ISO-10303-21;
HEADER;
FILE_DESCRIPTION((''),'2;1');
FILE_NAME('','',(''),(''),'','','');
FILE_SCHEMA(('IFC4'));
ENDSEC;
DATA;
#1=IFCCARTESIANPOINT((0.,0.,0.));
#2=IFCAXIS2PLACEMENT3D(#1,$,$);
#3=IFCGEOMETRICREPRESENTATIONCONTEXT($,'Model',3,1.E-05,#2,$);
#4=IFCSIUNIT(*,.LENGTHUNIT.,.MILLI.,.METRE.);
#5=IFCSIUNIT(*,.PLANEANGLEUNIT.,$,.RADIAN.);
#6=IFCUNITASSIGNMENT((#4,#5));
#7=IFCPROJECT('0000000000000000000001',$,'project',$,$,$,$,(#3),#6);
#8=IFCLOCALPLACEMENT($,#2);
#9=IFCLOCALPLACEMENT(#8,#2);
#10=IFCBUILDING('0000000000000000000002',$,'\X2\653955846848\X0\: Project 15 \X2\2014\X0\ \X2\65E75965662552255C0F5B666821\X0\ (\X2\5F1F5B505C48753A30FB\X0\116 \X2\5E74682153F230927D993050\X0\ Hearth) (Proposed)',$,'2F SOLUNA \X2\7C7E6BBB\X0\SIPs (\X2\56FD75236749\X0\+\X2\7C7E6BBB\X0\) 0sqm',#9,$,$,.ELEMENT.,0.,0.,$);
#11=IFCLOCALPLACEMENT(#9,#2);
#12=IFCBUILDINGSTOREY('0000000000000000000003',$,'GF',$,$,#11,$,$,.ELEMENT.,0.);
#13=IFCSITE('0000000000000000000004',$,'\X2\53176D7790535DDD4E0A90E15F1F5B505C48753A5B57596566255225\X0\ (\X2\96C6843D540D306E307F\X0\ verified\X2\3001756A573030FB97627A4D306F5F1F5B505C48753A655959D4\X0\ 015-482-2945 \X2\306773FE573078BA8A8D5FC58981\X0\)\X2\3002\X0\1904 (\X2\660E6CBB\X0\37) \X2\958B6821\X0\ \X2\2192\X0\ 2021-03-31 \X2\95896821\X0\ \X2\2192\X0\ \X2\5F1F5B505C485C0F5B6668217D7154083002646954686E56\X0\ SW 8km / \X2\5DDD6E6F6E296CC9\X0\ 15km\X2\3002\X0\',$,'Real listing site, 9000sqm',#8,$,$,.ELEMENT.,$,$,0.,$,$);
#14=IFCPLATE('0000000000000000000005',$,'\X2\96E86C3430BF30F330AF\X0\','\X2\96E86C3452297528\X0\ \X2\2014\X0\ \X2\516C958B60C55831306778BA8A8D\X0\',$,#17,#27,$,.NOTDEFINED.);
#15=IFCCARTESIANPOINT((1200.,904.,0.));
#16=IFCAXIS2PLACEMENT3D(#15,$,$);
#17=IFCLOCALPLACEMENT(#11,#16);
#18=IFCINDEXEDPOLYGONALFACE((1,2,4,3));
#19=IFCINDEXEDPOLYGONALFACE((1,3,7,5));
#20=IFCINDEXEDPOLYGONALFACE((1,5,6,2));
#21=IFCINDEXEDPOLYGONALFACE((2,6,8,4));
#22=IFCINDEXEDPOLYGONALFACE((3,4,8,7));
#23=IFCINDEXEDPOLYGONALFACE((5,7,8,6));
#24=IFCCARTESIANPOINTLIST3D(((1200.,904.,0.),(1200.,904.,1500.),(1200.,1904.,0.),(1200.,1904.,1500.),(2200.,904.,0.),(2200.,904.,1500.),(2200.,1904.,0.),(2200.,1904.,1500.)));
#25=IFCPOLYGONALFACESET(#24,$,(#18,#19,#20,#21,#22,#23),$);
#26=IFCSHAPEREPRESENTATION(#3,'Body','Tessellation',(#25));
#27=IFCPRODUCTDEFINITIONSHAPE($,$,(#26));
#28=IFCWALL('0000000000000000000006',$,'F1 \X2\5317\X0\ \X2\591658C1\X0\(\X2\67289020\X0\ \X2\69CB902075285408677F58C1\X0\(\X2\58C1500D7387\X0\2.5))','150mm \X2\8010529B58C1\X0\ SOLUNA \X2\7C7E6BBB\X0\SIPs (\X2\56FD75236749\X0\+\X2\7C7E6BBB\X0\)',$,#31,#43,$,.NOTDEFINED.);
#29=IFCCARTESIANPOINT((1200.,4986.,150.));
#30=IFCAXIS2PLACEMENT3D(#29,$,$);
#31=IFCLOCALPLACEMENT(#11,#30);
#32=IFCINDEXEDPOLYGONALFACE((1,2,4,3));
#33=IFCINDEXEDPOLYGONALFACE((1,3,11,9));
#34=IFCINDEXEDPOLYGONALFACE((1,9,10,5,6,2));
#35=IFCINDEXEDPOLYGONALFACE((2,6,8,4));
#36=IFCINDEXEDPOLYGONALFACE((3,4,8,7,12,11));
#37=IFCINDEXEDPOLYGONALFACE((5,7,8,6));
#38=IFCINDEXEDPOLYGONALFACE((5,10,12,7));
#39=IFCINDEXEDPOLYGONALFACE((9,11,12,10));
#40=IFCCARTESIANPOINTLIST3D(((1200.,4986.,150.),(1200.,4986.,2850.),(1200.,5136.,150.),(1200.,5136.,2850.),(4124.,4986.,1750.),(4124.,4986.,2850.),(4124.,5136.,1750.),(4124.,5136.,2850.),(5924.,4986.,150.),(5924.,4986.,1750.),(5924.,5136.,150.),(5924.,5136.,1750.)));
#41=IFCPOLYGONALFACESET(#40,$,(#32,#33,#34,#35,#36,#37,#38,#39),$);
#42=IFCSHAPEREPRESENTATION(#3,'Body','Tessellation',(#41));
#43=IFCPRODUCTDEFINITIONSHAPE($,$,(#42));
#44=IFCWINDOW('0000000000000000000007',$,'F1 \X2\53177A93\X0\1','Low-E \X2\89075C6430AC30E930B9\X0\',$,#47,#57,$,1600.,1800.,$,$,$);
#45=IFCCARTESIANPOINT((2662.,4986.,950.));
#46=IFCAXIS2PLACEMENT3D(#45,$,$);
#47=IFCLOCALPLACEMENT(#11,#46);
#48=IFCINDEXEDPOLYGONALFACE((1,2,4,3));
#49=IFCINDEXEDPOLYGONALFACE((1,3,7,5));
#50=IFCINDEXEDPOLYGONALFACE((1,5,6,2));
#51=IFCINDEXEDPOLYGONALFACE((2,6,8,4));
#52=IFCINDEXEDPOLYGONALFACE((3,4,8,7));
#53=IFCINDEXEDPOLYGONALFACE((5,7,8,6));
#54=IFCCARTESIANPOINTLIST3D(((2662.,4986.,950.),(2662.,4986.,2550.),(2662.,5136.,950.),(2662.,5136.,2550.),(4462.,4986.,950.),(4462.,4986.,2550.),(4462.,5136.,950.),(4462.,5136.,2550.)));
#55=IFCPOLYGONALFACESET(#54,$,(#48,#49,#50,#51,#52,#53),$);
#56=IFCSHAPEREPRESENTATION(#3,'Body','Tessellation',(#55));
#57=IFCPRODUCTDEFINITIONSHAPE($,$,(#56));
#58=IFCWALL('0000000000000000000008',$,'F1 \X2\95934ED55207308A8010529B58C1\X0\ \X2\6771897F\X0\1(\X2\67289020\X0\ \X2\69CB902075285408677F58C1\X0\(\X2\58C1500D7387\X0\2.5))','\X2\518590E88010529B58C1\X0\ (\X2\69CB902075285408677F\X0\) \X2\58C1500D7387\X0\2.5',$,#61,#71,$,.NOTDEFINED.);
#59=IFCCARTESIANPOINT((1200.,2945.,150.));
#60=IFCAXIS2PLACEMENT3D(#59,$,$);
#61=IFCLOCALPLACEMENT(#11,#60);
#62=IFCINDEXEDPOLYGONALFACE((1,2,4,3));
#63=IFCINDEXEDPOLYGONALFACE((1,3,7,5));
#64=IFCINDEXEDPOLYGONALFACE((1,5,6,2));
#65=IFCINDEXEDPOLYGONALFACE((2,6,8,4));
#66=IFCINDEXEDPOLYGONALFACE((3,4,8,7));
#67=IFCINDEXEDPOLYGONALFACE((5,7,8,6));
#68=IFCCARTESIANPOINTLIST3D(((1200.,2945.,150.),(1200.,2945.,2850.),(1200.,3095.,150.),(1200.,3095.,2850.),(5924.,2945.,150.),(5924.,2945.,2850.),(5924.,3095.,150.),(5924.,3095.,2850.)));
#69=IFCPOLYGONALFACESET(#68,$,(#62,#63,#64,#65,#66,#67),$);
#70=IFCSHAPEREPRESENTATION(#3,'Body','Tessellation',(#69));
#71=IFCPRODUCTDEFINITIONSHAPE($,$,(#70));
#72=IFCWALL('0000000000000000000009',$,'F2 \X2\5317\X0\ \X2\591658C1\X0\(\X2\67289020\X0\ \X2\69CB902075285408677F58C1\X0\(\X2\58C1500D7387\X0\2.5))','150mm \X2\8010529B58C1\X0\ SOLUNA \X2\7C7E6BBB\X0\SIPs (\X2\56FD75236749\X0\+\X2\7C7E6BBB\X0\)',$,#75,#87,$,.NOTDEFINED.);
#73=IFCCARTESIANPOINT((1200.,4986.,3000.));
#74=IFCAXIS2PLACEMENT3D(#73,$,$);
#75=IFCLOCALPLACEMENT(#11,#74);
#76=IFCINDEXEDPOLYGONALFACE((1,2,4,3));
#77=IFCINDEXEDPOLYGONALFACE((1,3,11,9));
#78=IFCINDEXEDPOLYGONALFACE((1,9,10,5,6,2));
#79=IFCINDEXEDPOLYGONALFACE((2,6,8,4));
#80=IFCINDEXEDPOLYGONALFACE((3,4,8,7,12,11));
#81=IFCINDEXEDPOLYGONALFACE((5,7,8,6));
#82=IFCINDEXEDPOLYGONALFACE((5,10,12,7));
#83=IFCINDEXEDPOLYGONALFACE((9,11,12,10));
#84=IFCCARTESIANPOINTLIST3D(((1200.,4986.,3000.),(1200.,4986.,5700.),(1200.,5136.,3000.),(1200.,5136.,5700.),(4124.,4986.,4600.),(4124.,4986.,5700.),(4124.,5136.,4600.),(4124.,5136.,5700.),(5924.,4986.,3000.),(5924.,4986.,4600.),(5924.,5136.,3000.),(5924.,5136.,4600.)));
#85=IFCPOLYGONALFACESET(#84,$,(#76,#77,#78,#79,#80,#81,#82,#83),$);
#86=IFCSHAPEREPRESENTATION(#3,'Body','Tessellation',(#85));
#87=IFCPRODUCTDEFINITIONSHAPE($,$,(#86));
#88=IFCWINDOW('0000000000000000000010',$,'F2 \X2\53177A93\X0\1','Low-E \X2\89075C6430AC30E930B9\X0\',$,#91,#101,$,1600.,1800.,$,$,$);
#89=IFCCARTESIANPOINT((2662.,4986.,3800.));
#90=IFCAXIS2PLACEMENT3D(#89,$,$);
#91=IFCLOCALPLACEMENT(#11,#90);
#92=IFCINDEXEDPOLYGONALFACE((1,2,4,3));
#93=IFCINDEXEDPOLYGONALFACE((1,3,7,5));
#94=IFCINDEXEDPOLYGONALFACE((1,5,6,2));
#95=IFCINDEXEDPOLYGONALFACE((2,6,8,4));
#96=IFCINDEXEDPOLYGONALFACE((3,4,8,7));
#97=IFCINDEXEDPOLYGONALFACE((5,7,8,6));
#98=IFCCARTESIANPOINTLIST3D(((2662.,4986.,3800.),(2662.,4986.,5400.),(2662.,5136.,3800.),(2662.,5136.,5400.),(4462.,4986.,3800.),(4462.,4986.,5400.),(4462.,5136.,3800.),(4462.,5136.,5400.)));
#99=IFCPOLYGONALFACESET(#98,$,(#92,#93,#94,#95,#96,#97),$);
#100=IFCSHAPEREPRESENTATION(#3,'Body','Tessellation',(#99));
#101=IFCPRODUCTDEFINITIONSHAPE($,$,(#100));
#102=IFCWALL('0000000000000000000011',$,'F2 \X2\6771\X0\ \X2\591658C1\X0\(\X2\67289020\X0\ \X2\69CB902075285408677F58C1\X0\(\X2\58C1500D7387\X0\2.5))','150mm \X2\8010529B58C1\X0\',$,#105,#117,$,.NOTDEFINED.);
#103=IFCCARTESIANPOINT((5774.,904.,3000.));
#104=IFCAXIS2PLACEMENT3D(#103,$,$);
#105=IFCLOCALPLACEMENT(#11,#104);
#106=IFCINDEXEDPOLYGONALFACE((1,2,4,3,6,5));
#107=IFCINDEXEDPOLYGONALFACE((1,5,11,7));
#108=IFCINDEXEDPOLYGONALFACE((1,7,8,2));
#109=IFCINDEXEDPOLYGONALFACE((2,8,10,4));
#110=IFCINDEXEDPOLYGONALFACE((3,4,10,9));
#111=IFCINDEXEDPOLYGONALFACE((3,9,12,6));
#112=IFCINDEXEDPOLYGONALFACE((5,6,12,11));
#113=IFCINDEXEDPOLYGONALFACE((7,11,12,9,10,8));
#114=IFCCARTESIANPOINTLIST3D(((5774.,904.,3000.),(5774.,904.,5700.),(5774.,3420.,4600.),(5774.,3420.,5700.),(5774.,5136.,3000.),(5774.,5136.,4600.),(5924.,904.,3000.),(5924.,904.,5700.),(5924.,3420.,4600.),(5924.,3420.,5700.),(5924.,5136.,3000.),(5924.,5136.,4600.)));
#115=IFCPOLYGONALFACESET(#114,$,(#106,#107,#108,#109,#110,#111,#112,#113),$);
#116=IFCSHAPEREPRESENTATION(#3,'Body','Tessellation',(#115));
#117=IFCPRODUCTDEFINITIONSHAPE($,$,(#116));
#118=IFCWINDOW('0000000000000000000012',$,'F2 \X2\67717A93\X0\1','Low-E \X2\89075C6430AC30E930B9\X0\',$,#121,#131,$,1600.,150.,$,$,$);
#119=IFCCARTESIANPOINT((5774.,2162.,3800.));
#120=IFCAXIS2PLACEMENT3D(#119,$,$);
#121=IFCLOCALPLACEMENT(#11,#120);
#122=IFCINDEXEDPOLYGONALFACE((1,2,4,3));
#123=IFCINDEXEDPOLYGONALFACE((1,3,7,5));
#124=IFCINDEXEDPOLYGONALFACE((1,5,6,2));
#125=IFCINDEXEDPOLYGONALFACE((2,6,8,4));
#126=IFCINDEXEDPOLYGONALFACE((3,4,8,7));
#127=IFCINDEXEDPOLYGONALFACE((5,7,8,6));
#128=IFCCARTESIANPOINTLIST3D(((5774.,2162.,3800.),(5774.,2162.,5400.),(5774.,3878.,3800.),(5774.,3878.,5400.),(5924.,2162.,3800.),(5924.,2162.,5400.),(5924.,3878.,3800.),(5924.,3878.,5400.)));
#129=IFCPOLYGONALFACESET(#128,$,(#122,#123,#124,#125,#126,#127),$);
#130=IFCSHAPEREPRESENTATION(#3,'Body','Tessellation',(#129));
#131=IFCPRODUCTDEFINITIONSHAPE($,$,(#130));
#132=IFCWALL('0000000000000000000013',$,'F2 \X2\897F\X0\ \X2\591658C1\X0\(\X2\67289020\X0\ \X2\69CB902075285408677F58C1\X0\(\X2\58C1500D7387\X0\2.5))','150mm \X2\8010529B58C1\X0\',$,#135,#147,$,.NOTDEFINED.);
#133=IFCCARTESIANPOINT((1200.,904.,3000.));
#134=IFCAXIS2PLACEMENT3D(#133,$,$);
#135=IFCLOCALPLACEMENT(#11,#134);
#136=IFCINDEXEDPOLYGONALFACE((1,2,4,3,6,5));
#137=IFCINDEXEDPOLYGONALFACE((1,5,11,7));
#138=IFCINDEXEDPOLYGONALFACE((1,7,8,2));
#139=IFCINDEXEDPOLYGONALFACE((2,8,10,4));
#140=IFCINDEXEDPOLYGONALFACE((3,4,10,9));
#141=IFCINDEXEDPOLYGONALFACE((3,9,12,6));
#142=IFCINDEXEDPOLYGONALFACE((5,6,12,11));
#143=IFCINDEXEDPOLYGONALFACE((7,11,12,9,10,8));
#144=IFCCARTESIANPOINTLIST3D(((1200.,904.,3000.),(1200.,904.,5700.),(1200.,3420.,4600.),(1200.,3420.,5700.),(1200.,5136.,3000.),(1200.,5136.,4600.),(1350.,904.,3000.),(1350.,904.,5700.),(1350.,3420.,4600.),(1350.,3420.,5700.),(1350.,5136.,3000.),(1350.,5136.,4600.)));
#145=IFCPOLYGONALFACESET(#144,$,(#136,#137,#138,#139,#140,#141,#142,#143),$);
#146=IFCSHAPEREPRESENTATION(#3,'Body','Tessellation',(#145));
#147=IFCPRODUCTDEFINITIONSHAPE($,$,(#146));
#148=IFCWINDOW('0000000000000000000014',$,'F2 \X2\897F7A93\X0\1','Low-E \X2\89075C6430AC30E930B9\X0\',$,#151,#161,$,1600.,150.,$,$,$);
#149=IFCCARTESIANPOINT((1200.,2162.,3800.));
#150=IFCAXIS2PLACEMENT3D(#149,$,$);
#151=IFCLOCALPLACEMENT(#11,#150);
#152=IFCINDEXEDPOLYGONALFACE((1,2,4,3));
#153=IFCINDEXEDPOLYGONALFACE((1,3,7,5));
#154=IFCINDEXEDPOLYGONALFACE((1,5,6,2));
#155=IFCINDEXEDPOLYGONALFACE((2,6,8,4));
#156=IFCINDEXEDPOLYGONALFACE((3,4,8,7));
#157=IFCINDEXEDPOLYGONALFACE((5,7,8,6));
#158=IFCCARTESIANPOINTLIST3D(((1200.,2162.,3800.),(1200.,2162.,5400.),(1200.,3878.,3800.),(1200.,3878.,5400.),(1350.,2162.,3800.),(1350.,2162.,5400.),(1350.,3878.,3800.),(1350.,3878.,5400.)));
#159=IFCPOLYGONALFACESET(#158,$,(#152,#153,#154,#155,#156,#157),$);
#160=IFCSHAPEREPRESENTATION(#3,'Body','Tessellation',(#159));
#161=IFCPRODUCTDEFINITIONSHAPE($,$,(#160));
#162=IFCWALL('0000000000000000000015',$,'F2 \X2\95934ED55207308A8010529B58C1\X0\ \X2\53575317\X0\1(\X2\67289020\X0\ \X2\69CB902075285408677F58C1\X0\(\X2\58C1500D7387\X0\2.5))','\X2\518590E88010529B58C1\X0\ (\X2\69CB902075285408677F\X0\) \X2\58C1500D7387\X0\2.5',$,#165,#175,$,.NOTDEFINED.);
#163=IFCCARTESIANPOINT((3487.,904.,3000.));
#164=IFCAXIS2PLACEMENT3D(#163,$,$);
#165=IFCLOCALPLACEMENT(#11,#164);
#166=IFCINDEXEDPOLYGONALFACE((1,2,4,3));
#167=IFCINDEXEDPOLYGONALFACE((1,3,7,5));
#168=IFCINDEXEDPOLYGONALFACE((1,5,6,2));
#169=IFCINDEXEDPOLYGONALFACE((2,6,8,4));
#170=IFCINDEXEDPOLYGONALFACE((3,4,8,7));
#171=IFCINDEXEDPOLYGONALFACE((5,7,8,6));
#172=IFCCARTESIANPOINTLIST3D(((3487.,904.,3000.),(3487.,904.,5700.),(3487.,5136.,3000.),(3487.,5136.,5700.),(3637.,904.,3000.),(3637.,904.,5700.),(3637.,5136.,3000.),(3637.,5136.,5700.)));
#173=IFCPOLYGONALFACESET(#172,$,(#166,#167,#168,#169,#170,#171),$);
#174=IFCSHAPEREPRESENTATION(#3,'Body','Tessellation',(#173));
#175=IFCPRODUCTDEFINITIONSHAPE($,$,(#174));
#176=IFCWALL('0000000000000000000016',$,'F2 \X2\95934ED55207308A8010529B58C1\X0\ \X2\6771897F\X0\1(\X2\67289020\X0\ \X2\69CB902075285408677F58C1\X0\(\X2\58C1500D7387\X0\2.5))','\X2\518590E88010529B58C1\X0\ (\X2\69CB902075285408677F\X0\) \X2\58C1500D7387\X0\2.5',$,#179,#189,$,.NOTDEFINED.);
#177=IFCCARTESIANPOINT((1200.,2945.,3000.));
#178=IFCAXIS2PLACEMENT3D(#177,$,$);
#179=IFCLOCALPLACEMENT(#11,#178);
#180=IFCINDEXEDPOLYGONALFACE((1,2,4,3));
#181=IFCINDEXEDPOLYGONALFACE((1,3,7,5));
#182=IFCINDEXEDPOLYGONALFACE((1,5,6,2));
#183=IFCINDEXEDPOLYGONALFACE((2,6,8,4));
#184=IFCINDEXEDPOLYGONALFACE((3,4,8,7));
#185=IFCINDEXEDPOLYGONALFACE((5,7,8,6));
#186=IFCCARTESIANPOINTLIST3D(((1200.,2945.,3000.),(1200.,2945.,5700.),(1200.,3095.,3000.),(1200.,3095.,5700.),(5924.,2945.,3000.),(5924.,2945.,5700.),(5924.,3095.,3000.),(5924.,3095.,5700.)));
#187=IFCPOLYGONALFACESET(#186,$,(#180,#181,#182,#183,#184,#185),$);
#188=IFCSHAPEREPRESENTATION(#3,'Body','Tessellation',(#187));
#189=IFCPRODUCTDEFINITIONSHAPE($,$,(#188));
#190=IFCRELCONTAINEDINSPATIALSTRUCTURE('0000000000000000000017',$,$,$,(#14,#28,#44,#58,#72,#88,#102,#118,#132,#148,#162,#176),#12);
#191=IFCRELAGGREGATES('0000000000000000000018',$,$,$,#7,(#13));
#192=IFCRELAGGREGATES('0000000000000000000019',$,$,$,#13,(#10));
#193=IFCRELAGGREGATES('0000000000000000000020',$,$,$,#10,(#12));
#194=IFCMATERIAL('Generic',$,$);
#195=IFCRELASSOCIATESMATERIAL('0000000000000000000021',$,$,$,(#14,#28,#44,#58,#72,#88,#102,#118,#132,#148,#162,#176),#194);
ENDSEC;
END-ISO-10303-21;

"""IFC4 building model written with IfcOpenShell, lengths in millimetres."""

from ifc_helpers import new_model, si_unit, frame, frame_2d, origin, place, context, project, spatial, rectangle, extrude, material, element, fill, save


model = new_model("IFC4")

# Units and contexts
model_context = context("Model", 3, precision=1e-05, world=origin())
ifc_project = project(units=[si_unit("LENGTHUNIT", "METRE", prefix="MILLI"), si_unit("PLANEANGLEUNIT", "RADIAN")], contexts=[model_context])

# Site, building, storey
site_placement = place(None, origin())
site = spatial("IfcSite", under=ifc_project, at=site_placement, Name="北海道川上郡弟子屈町字奥春別 (集落名のみ verified、番地・面積は弟子屈町教委 015-482-2945 で現地確認必要)。1904 (明治37) 開校 → 2021-03-31 閉校 → 弟子屈小学校統合。摩周湖 SW 8km / 川湯温泉 15km。", ObjectType="Real listing site, 9000sqm", CompositionType="ELEMENT", RefElevation=0.0)
building_placement = place(site_placement, origin())
building = spatial("IfcBuilding", under=site, at=building_placement, Name="改善案: Project 15 — 旧奥春別小学校 (弟子屈町・116 年校史を継ぐ Hearth) (Proposed)", ObjectType="2F SOLUNA 籾殻SIPs (国産杉+籾殻) 0sqm", CompositionType="ELEMENT", ElevationOfRefHeight=0.0, ElevationOfTerrain=0.0)
storey_placement = place(building_placement, origin())
storey = spatial("IfcBuildingStorey", under=building, at=storey_placement, Name="GF", CompositionType="ELEMENT", Elevation=0.0)

# Plate
ifc_material_1 = material(Name="Generic")
plate_placement = place(storey_placement, frame((1200.0, 904.0, 0.0)))
element("IfcPlate", 1, at=plate_placement, inside=storey, material=ifc_material_1, Name="雨水タンク", Description="雨水利用 — 公開情報で確認", PredefinedType="NOTDEFINED", context=model_context, shape_type="SweptSolid", body=[
    extrude(rectangle(XDim=1000.0, YDim=1000.0, at=frame_2d((500.0, 500.0))), frame((1200.0, 904.0, 0.0)), (0.0, 0.0, 1.0), 1500.0),
])

# Wall, opening, window
wall_1_placement = place(storey_placement, frame((1200.0, 4986.0, 150.0)))
wall_1 = element("IfcWall", 2, at=wall_1_placement, inside=storey, material=ifc_material_1, Name="F1 北 外壁(木造 構造用合板壁(壁倍率2.5))", Description="150mm 耐力壁 SOLUNA 籾殻SIPs (国産杉+籾殻)", PredefinedType="NOTDEFINED", context=model_context, shape_type="SweptSolid", body=[
    extrude(rectangle(XDim=4724.0, YDim=150.0, at=frame_2d((2362.0, 75.0))), frame((1200.0, 4986.0, 150.0)), (0.0, 0.0, 1.0), 2700.0),
])
opening_1_placement = place(storey_placement, frame((2662.0, 4986.0, 950.0)))
opening_1 = element("IfcOpeningElement", 3, at=opening_1_placement, cuts=wall_1, PredefinedType="NOTDEFINED", context=model_context, shape_type="SweptSolid", body=[
    extrude(rectangle(XDim=1800.0, YDim=150.0, at=frame_2d((900.0, 75.0))), frame((2662.0, 4986.0, 950.0)), (0.0, 0.0, 1.0), 1600.0),
])
window_1_placement = place(storey_placement, frame((2662.0, 4986.0, 950.0)))
window_1 = element("IfcWindow", 4, at=window_1_placement, inside=storey, material=ifc_material_1, Name="F1 北窓1", Description="Low-E 複層ガラス", OverallHeight=1600.0, OverallWidth=1800.0, context=model_context, shape_type="SweptSolid", body=[
    extrude(rectangle(XDim=1800.0, YDim=150.0, at=frame_2d((900.0, 75.0))), frame((2662.0, 4986.0, 950.0)), (0.0, 0.0, 1.0), 1600.0),
])
fill(opening_1, window_1)

# Wall
wall_2_placement = place(storey_placement, frame((1200.0, 2945.0, 150.0)))
element("IfcWall", 5, at=wall_2_placement, inside=storey, material=ifc_material_1, Name="F1 間仕切り耐力壁 東西1(木造 構造用合板壁(壁倍率2.5))", Description="内部耐力壁 (構造用合板) 壁倍率2.5", PredefinedType="NOTDEFINED", context=model_context, shape_type="SweptSolid", body=[
    extrude(rectangle(XDim=4724.0, YDim=150.0, at=frame_2d((2362.0, 75.0))), frame((1200.0, 2945.0, 150.0)), (0.0, 0.0, 1.0), 2700.0),
])

# Walls, openings, windows
wall_3_placement = place(storey_placement, frame((1200.0, 4986.0, 3000.0)))
wall_3 = element("IfcWall", 6, at=wall_3_placement, inside=storey, material=ifc_material_1, Name="F2 北 外壁(木造 構造用合板壁(壁倍率2.5))", Description="150mm 耐力壁 SOLUNA 籾殻SIPs (国産杉+籾殻)", PredefinedType="NOTDEFINED", context=model_context, shape_type="SweptSolid", body=[
    extrude(rectangle(XDim=4724.0, YDim=150.0, at=frame_2d((2362.0, 75.0))), frame((1200.0, 4986.0, 3000.0)), (0.0, 0.0, 1.0), 2700.0),
])
opening_2_placement = place(storey_placement, frame((2662.0, 4986.0, 3800.0)))
opening_2 = element("IfcOpeningElement", 7, at=opening_2_placement, cuts=wall_3, PredefinedType="NOTDEFINED", context=model_context, shape_type="SweptSolid", body=[
    extrude(rectangle(XDim=1800.0, YDim=150.0, at=frame_2d((900.0, 75.0))), frame((2662.0, 4986.0, 3800.0)), (0.0, 0.0, 1.0), 1600.0),
])
window_2_placement = place(storey_placement, frame((2662.0, 4986.0, 3800.0)))
window_2 = element("IfcWindow", 8, at=window_2_placement, inside=storey, material=ifc_material_1, Name="F2 北窓1", Description="Low-E 複層ガラス", OverallHeight=1600.0, OverallWidth=1800.0, context=model_context, shape_type="SweptSolid", body=[
    extrude(rectangle(XDim=1800.0, YDim=150.0, at=frame_2d((900.0, 75.0))), frame((2662.0, 4986.0, 3800.0)), (0.0, 0.0, 1.0), 1600.0),
])
fill(opening_2, window_2)
wall_4_placement = place(storey_placement, frame((5774.0, 904.0, 3000.0)))
wall_4 = element("IfcWall", 9, at=wall_4_placement, inside=storey, material=ifc_material_1, Name="F2 東 外壁(木造 構造用合板壁(壁倍率2.5))", Description="150mm 耐力壁", PredefinedType="NOTDEFINED", context=model_context, shape_type="SweptSolid", body=[
    extrude(rectangle(XDim=150.0, YDim=4232.0, at=frame_2d((75.0, 2116.0))), frame((5774.0, 904.0, 3000.0)), (0.0, 0.0, 1.0), 2700.0),
])
opening_3_placement = place(storey_placement, frame((5774.0, 2162.0, 3800.0)))
opening_3 = element("IfcOpeningElement", 10, at=opening_3_placement, cuts=wall_4, PredefinedType="NOTDEFINED", context=model_context, shape_type="SweptSolid", body=[
    extrude(rectangle(XDim=150.0, YDim=1716.0, at=frame_2d((75.0, 858.0))), frame((5774.0, 2162.0, 3800.0)), (0.0, 0.0, 1.0), 1600.0),
])
window_3_placement = place(storey_placement, frame((5774.0, 2162.0, 3800.0)))
window_3 = element("IfcWindow", 11, at=window_3_placement, inside=storey, material=ifc_material_1, Name="F2 東窓1", Description="Low-E 複層ガラス", OverallHeight=1600.0, OverallWidth=150.0, context=model_context, shape_type="SweptSolid", body=[
    extrude(rectangle(XDim=150.0, YDim=1716.0, at=frame_2d((75.0, 858.0))), frame((5774.0, 2162.0, 3800.0)), (0.0, 0.0, 1.0), 1600.0),
])
fill(opening_3, window_3)
wall_5_placement = place(storey_placement, frame((1200.0, 904.0, 3000.0)))
wall_5 = element("IfcWall", 12, at=wall_5_placement, inside=storey, material=ifc_material_1, Name="F2 西 外壁(木造 構造用合板壁(壁倍率2.5))", Description="150mm 耐力壁", PredefinedType="NOTDEFINED", context=model_context, shape_type="SweptSolid", body=[
    extrude(rectangle(XDim=150.0, YDim=4232.0, at=frame_2d((75.0, 2116.0))), frame((1200.0, 904.0, 3000.0)), (0.0, 0.0, 1.0), 2700.0),
])
opening_4_placement = place(storey_placement, frame((1200.0, 2162.0, 3800.0)))
opening_4 = element("IfcOpeningElement", 13, at=opening_4_placement, cuts=wall_5, PredefinedType="NOTDEFINED", context=model_context, shape_type="SweptSolid", body=[
    extrude(rectangle(XDim=150.0, YDim=1716.0, at=frame_2d((75.0, 858.0))), frame((1200.0, 2162.0, 3800.0)), (0.0, 0.0, 1.0), 1600.0),
])
window_4_placement = place(storey_placement, frame((1200.0, 2162.0, 3800.0)))
window_4 = element("IfcWindow", 14, at=window_4_placement, inside=storey, material=ifc_material_1, Name="F2 西窓1", Description="Low-E 複層ガラス", OverallHeight=1600.0, OverallWidth=150.0, context=model_context, shape_type="SweptSolid", body=[
    extrude(rectangle(XDim=150.0, YDim=1716.0, at=frame_2d((75.0, 858.0))), frame((1200.0, 2162.0, 3800.0)), (0.0, 0.0, 1.0), 1600.0),
])
fill(opening_4, window_4)

# Walls
wall_6_placement = place(storey_placement, frame((3487.0, 904.0, 3000.0)))
element("IfcWall", 15, at=wall_6_placement, inside=storey, material=ifc_material_1, Name="F2 間仕切り耐力壁 南北1(木造 構造用合板壁(壁倍率2.5))", Description="内部耐力壁 (構造用合板) 壁倍率2.5", PredefinedType="NOTDEFINED", context=model_context, shape_type="SweptSolid", body=[
    extrude(rectangle(XDim=150.0, YDim=4232.0, at=frame_2d((75.0, 2116.0))), frame((3487.0, 904.0, 3000.0)), (0.0, 0.0, 1.0), 2700.0),
])
wall_7_placement = place(storey_placement, frame((1200.0, 2945.0, 3000.0)))
element("IfcWall", 16, at=wall_7_placement, inside=storey, material=ifc_material_1, Name="F2 間仕切り耐力壁 東西1(木造 構造用合板壁(壁倍率2.5))", Description="内部耐力壁 (構造用合板) 壁倍率2.5", PredefinedType="NOTDEFINED", context=model_context, shape_type="SweptSolid", body=[
    extrude(rectangle(XDim=4724.0, YDim=150.0, at=frame_2d((2362.0, 75.0))), frame((1200.0, 2945.0, 3000.0)), (0.0, 0.0, 1.0), 2700.0),
])

save(model, "model.ifc")
